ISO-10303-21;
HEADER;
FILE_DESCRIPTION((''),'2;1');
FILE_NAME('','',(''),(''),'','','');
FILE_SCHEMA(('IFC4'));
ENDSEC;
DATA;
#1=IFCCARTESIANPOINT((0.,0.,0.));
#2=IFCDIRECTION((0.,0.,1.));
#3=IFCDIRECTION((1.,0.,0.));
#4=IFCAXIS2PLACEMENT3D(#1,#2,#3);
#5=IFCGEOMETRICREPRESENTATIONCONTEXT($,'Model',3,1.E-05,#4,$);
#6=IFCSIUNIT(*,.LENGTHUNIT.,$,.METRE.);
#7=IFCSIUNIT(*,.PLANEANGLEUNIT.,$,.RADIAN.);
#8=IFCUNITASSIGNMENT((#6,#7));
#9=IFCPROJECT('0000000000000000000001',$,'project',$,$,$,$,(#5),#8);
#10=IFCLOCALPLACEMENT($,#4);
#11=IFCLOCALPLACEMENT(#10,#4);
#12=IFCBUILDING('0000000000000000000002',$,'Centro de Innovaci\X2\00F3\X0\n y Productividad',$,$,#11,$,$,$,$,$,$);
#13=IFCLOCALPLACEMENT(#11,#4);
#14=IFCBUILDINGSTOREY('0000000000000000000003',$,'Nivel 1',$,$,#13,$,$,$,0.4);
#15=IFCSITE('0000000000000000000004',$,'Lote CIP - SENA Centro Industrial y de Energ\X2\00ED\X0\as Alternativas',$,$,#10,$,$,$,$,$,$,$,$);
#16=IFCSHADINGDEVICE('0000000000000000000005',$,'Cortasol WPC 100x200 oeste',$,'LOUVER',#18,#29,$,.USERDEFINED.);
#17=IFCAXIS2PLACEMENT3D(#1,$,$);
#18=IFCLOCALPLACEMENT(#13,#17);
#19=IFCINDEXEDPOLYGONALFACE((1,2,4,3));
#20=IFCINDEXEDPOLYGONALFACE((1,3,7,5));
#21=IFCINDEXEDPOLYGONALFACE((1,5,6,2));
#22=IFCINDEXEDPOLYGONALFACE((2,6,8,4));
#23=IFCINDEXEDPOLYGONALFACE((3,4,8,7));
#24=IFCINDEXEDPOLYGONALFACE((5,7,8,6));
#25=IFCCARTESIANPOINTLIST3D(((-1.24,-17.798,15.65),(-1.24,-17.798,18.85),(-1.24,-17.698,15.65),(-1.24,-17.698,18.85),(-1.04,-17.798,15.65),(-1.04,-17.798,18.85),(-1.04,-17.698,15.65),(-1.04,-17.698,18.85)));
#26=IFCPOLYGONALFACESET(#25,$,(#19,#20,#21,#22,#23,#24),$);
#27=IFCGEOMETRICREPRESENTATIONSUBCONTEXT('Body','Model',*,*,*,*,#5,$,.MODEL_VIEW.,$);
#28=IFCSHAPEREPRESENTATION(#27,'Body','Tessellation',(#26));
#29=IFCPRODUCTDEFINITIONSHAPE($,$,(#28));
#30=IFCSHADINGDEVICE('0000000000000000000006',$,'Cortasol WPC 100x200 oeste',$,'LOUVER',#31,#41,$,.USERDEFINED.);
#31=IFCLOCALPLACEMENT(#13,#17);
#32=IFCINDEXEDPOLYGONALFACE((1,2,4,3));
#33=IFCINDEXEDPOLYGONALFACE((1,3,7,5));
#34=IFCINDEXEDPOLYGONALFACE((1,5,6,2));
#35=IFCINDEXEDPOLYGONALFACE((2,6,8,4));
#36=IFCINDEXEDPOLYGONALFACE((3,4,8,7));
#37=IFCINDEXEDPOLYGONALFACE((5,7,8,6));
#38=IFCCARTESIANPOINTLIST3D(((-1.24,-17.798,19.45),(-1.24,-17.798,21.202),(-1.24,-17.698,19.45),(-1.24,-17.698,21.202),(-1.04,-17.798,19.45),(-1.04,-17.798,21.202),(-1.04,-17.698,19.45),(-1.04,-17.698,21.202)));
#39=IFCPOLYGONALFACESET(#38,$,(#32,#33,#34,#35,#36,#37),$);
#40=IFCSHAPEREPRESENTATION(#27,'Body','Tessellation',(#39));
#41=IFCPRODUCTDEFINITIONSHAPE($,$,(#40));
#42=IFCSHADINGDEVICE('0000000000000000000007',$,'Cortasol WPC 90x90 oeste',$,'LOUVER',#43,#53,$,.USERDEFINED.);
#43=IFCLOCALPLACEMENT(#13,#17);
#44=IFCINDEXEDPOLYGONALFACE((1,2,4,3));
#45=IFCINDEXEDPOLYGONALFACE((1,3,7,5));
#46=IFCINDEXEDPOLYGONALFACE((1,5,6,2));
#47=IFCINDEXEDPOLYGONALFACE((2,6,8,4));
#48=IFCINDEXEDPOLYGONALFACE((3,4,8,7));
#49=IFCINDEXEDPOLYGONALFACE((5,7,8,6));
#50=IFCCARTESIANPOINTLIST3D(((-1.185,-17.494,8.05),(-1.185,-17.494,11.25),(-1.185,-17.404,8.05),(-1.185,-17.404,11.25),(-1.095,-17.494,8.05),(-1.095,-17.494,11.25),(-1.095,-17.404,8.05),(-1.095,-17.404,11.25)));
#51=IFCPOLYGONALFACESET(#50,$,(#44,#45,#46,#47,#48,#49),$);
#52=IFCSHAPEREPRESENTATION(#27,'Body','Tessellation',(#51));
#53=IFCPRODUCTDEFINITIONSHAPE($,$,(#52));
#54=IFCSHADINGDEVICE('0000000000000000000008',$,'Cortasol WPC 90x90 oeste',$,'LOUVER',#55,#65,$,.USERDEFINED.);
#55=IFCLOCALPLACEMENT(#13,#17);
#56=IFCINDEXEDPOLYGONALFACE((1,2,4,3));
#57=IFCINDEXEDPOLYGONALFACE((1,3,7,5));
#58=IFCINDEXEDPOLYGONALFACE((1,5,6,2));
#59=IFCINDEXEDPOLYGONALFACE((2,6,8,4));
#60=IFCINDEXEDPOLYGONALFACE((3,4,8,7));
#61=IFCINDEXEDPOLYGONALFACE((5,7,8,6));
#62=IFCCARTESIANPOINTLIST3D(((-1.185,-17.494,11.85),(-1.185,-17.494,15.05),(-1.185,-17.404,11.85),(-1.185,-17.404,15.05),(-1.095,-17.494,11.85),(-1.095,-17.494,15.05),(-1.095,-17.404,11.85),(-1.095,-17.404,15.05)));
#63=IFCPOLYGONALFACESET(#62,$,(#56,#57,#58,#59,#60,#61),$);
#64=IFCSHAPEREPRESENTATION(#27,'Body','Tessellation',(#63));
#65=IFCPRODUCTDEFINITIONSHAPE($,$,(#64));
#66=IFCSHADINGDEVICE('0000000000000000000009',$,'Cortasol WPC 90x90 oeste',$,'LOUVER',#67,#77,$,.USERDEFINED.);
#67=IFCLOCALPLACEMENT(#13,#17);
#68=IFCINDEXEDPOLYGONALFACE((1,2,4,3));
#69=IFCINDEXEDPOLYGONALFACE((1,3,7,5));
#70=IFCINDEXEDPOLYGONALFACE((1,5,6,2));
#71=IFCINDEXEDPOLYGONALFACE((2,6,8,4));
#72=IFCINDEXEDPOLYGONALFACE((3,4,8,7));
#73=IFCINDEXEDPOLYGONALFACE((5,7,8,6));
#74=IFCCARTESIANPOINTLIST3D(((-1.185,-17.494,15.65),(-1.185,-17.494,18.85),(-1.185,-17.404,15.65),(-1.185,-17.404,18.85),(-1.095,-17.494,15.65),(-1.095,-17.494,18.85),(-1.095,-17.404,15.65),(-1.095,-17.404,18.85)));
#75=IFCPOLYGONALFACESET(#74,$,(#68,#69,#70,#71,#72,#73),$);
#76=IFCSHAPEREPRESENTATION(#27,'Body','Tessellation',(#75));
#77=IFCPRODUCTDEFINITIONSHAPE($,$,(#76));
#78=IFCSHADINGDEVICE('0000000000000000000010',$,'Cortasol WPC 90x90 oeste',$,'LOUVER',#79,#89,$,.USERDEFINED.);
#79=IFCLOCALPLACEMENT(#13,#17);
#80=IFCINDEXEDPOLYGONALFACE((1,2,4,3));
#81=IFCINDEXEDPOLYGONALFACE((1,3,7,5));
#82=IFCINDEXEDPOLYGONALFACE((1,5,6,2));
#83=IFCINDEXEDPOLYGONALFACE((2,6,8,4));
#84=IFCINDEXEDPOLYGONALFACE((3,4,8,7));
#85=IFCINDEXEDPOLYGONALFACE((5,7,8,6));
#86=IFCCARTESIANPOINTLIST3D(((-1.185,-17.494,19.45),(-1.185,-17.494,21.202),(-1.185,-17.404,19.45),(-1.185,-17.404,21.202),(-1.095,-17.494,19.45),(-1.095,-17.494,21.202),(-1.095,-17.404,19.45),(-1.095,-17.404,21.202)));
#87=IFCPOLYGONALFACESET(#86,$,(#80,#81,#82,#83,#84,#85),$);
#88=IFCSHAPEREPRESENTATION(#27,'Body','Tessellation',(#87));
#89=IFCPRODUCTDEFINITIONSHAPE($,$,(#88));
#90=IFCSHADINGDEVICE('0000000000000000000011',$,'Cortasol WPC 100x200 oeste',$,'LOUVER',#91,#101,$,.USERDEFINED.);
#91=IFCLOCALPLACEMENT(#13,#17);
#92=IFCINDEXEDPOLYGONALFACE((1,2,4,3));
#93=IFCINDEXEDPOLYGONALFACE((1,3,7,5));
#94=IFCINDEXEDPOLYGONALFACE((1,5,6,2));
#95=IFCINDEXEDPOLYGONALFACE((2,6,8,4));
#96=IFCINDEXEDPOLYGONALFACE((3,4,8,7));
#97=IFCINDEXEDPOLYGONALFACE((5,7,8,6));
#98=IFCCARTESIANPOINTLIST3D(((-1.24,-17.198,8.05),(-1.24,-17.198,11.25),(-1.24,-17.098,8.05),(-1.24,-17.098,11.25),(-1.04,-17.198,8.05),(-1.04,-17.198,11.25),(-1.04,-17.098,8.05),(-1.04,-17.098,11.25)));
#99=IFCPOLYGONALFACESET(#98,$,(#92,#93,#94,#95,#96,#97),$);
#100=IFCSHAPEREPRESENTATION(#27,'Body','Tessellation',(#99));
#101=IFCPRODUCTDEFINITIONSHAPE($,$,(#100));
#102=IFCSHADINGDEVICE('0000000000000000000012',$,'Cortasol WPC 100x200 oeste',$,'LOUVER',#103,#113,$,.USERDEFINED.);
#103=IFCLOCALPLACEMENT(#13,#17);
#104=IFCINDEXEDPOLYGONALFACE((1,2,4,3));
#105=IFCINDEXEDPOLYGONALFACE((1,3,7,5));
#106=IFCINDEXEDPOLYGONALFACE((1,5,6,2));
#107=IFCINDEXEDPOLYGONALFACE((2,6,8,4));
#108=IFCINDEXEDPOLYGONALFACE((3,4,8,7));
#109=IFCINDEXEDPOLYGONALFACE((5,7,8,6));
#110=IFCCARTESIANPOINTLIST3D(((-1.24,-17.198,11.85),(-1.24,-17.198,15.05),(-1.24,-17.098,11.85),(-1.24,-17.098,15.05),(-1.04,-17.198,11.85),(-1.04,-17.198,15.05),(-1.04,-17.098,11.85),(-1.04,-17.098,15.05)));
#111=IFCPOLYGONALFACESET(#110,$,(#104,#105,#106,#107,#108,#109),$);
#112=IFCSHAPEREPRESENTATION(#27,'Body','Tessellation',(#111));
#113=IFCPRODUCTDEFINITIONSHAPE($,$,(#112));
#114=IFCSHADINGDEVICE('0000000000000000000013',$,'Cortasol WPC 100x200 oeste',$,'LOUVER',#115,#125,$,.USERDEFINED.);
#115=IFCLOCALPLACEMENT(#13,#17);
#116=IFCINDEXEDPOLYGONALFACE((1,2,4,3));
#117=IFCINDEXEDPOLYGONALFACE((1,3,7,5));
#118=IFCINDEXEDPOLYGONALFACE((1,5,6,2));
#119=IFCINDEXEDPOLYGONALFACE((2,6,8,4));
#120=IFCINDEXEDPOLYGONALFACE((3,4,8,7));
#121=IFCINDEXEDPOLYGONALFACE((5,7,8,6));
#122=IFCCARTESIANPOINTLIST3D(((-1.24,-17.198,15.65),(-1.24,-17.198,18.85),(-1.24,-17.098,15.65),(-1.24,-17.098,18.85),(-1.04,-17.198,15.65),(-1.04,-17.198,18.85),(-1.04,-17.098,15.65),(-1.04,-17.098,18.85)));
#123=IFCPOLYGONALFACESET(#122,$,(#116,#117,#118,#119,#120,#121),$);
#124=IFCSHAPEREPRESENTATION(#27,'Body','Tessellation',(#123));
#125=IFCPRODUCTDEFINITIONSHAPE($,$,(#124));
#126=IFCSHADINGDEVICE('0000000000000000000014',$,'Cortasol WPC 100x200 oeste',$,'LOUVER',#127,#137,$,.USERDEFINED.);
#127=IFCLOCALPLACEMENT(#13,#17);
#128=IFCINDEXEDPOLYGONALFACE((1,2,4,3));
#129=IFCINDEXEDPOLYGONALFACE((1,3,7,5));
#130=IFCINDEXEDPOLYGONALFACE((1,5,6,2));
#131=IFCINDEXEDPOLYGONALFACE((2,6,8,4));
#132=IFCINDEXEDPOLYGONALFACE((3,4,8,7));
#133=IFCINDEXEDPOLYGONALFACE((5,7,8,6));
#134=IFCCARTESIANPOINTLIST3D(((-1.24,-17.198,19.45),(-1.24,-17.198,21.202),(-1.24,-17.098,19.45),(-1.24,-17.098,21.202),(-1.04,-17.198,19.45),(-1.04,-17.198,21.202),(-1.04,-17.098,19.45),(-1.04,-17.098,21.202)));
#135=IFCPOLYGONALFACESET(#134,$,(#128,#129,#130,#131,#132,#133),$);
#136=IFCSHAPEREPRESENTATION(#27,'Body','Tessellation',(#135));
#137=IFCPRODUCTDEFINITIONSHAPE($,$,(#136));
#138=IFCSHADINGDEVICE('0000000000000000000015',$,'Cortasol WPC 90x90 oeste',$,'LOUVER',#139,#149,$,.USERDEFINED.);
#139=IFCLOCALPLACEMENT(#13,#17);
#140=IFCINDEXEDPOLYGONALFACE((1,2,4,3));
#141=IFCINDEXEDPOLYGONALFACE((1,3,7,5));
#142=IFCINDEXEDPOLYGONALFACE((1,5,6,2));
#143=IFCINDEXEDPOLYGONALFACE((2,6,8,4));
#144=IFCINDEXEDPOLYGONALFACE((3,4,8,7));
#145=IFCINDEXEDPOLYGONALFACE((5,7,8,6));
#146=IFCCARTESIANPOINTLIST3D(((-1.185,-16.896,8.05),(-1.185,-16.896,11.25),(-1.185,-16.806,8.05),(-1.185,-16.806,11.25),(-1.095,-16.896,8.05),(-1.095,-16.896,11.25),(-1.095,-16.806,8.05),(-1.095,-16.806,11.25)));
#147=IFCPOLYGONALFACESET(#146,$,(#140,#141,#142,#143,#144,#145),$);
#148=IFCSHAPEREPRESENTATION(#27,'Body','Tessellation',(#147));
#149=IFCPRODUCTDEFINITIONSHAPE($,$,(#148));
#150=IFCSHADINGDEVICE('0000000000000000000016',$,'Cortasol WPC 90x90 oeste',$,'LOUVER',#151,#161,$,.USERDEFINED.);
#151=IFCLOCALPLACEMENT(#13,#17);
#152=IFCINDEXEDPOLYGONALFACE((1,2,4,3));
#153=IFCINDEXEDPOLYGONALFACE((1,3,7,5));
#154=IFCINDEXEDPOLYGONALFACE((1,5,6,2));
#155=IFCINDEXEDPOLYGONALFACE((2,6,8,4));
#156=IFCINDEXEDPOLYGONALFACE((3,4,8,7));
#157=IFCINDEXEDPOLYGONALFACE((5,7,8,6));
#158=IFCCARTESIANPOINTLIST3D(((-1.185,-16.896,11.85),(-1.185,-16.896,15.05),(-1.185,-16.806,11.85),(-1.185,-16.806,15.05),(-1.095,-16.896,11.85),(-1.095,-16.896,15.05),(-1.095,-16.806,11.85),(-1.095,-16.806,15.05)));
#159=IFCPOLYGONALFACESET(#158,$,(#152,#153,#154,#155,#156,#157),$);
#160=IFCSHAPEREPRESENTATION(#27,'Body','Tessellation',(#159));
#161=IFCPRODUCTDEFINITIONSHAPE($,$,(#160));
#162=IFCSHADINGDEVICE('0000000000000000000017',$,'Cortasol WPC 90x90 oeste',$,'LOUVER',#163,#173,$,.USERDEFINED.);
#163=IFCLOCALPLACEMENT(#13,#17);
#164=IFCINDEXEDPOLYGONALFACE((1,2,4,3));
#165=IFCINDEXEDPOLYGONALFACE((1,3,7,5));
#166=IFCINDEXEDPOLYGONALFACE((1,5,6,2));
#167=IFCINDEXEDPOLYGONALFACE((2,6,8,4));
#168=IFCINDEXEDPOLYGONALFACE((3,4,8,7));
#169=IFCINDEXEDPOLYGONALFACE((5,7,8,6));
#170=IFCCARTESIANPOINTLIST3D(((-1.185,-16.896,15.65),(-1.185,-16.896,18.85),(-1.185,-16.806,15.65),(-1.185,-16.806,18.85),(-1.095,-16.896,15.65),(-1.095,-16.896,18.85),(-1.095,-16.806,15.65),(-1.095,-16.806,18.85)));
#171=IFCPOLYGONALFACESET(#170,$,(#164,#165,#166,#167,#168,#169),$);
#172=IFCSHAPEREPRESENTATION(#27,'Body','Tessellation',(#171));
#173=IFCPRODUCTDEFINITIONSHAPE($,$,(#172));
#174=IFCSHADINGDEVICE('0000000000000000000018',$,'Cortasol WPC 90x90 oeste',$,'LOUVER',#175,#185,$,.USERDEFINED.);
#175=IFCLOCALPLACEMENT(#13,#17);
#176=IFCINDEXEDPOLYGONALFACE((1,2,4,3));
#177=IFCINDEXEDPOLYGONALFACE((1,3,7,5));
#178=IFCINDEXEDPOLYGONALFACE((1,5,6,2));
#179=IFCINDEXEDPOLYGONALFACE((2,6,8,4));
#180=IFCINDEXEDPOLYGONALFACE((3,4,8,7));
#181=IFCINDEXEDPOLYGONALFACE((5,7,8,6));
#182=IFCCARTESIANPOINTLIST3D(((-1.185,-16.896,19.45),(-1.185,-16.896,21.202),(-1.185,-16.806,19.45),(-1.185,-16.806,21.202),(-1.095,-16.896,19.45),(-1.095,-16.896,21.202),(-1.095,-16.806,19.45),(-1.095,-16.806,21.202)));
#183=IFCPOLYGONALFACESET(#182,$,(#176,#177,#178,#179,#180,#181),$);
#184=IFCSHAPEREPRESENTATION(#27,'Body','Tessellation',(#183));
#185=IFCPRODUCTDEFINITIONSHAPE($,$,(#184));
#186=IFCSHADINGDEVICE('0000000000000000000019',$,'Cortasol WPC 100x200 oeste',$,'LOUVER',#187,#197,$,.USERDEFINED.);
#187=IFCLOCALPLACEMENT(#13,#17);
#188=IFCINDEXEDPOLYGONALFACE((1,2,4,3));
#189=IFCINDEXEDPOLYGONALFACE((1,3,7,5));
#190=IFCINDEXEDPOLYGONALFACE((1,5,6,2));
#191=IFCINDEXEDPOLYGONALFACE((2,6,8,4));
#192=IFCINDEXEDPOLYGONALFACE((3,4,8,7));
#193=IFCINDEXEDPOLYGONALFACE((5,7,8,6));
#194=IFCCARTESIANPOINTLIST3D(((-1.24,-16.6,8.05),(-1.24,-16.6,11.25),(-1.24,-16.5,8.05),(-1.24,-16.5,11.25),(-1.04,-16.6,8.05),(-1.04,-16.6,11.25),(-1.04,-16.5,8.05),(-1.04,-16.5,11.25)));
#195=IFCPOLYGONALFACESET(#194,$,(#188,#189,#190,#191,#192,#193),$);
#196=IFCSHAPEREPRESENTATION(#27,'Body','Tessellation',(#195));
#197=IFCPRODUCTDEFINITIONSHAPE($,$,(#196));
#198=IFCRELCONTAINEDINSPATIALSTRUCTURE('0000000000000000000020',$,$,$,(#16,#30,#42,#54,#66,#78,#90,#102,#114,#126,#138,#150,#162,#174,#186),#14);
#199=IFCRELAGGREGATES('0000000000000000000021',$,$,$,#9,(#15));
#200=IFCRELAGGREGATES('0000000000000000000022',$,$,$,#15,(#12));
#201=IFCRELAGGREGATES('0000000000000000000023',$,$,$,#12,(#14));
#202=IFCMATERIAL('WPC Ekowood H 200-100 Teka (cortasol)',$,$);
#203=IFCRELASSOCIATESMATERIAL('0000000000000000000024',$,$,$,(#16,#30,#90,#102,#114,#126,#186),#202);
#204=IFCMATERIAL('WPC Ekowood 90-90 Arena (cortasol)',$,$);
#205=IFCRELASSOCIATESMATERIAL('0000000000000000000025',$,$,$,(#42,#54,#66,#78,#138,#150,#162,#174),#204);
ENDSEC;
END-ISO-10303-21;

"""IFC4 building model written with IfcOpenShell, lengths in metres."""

from ifc_helpers import new_model, si_unit, frame, origin_with_axes, place, context, subcontext, project, spatial, polyline, outline, extrude, material, element, save


model = new_model("IFC4")

# Units and contexts
model_context = context("Model", 3, precision=1e-05, world=origin_with_axes())
body_context = subcontext(model_context, "Body", "Model", "MODEL_VIEW")
ifc_project = project(units=[si_unit("LENGTHUNIT", "METRE"), si_unit("PLANEANGLEUNIT", "RADIAN")], contexts=[model_context])

# Site, building, storey
site_placement = place(None, origin_with_axes())
site = spatial("IfcSite", under=ifc_project, at=site_placement, Name="Lote CIP - SENA Centro Industrial y de Energías Alternativas")
building_placement = place(site_placement, origin_with_axes())
building = spatial("IfcBuilding", under=site, at=building_placement, Name="Centro de Innovación y Productividad")
storey_placement = place(building_placement, origin_with_axes())
storey = spatial("IfcBuildingStorey", under=building, at=storey_placement, Name="Nivel 1", Elevation=0.4)

# Shading devices
ifc_material_1 = material(Name="WPC Ekowood H 200-100 Teka (cortasol)")
shading_device_1_placement = place(storey_placement, origin_with_axes())
element("IfcShadingDevice", 1, at=shading_device_1_placement, inside=storey, material=ifc_material_1, Name="Cortasol WPC 100x200 oeste", ObjectType="LOUVER", PredefinedType="USERDEFINED", context=body_context, shape_type="SweptSolid", body=[
    extrude(outline(polyline([(-1.04, -17.798), (-1.24, -17.798), (-1.24, -17.698), (-1.04, -17.698), (-1.04, -17.798)])), frame((0.0, 0.0, 15.65)), (0.0, 0.0, 1.0), 3.2),
])
shading_device_2_placement = place(storey_placement, origin_with_axes())
element("IfcShadingDevice", 2, at=shading_device_2_placement, inside=storey, material=ifc_material_1, Name="Cortasol WPC 100x200 oeste", ObjectType="LOUVER", PredefinedType="USERDEFINED", context=body_context, shape_type="SweptSolid", body=[
    extrude(outline(polyline([(-1.04, -17.798), (-1.24, -17.798), (-1.24, -17.698), (-1.04, -17.698), (-1.04, -17.798)])), frame((0.0, 0.0, 19.45)), (0.0, 0.0, 1.0), 1.752),
])
ifc_material_2 = material(Name="WPC Ekowood 90-90 Arena (cortasol)")
shading_device_3_placement = place(storey_placement, origin_with_axes())
element("IfcShadingDevice", 3, at=shading_device_3_placement, inside=storey, material=ifc_material_2, Name="Cortasol WPC 90x90 oeste", ObjectType="LOUVER", PredefinedType="USERDEFINED", context=body_context, shape_type="SweptSolid", body=[
    extrude(outline(polyline([(-1.095, -17.494), (-1.185, -17.494), (-1.185, -17.404), (-1.095, -17.404), (-1.095, -17.494)])), frame((0.0, 0.0, 8.05)), (0.0, 0.0, 1.0), 3.2),
])
shading_device_4_placement = place(storey_placement, origin_with_axes())
element("IfcShadingDevice", 4, at=shading_device_4_placement, inside=storey, material=ifc_material_2, Name="Cortasol WPC 90x90 oeste", ObjectType="LOUVER", PredefinedType="USERDEFINED", context=body_context, shape_type="SweptSolid", body=[
    extrude(outline(polyline([(-1.095, -17.494), (-1.185, -17.494), (-1.185, -17.404), (-1.095, -17.404), (-1.095, -17.494)])), frame((0.0, 0.0, 11.85)), (0.0, 0.0, 1.0), 3.2),
])
shading_device_5_placement = place(storey_placement, origin_with_axes())
element("IfcShadingDevice", 5, at=shading_device_5_placement, inside=storey, material=ifc_material_2, Name="Cortasol WPC 90x90 oeste", ObjectType="LOUVER", PredefinedType="USERDEFINED", context=body_context, shape_type="SweptSolid", body=[
    extrude(outline(polyline([(-1.095, -17.494), (-1.185, -17.494), (-1.185, -17.404), (-1.095, -17.404), (-1.095, -17.494)])), frame((0.0, 0.0, 15.65)), (0.0, 0.0, 1.0), 3.2),
])
shading_device_6_placement = place(storey_placement, origin_with_axes())
element("IfcShadingDevice", 6, at=shading_device_6_placement, inside=storey, material=ifc_material_2, Name="Cortasol WPC 90x90 oeste", ObjectType="LOUVER", PredefinedType="USERDEFINED", context=body_context, shape_type="SweptSolid", body=[
    extrude(outline(polyline([(-1.095, -17.494), (-1.185, -17.494), (-1.185, -17.404), (-1.095, -17.404), (-1.095, -17.494)])), frame((0.0, 0.0, 19.45)), (0.0, 0.0, 1.0), 1.752),
])
shading_device_7_placement = place(storey_placement, origin_with_axes())
element("IfcShadingDevice", 7, at=shading_device_7_placement, inside=storey, material=ifc_material_1, Name="Cortasol WPC 100x200 oeste", ObjectType="LOUVER", PredefinedType="USERDEFINED", context=body_context, shape_type="SweptSolid", body=[
    extrude(outline(polyline([(-1.04, -17.198), (-1.24, -17.198), (-1.24, -17.098), (-1.04, -17.098), (-1.04, -17.198)])), frame((0.0, 0.0, 8.05)), (0.0, 0.0, 1.0), 3.2),
])
shading_device_8_placement = place(storey_placement, origin_with_axes())
element("IfcShadingDevice", 8, at=shading_device_8_placement, inside=storey, material=ifc_material_1, Name="Cortasol WPC 100x200 oeste", ObjectType="LOUVER", PredefinedType="USERDEFINED", context=body_context, shape_type="SweptSolid", body=[
    extrude(outline(polyline([(-1.04, -17.198), (-1.24, -17.198), (-1.24, -17.098), (-1.04, -17.098), (-1.04, -17.198)])), frame((0.0, 0.0, 11.85)), (0.0, 0.0, 1.0), 3.2),
])
shading_device_9_placement = place(storey_placement, origin_with_axes())
element("IfcShadingDevice", 9, at=shading_device_9_placement, inside=storey, material=ifc_material_1, Name="Cortasol WPC 100x200 oeste", ObjectType="LOUVER", PredefinedType="USERDEFINED", context=body_context, shape_type="SweptSolid", body=[
    extrude(outline(polyline([(-1.04, -17.198), (-1.24, -17.198), (-1.24, -17.098), (-1.04, -17.098), (-1.04, -17.198)])), frame((0.0, 0.0, 15.65)), (0.0, 0.0, 1.0), 3.2),
])
shading_device_10_placement = place(storey_placement, origin_with_axes())
element("IfcShadingDevice", 10, at=shading_device_10_placement, inside=storey, material=ifc_material_1, Name="Cortasol WPC 100x200 oeste", ObjectType="LOUVER", PredefinedType="USERDEFINED", context=body_context, shape_type="SweptSolid", body=[
    extrude(outline(polyline([(-1.04, -17.198), (-1.24, -17.198), (-1.24, -17.098), (-1.04, -17.098), (-1.04, -17.198)])), frame((0.0, 0.0, 19.45)), (0.0, 0.0, 1.0), 1.752),
])
shading_device_11_placement = place(storey_placement, origin_with_axes())
element("IfcShadingDevice", 11, at=shading_device_11_placement, inside=storey, material=ifc_material_2, Name="Cortasol WPC 90x90 oeste", ObjectType="LOUVER", PredefinedType="USERDEFINED", context=body_context, shape_type="SweptSolid", body=[
    extrude(outline(polyline([(-1.095, -16.896), (-1.185, -16.896), (-1.185, -16.806), (-1.095, -16.806), (-1.095, -16.896)])), frame((0.0, 0.0, 8.05)), (0.0, 0.0, 1.0), 3.2),
])
shading_device_12_placement = place(storey_placement, origin_with_axes())
element("IfcShadingDevice", 12, at=shading_device_12_placement, inside=storey, material=ifc_material_2, Name="Cortasol WPC 90x90 oeste", ObjectType="LOUVER", PredefinedType="USERDEFINED", context=body_context, shape_type="SweptSolid", body=[
    extrude(outline(polyline([(-1.095, -16.896), (-1.185, -16.896), (-1.185, -16.806), (-1.095, -16.806), (-1.095, -16.896)])), frame((0.0, 0.0, 11.85)), (0.0, 0.0, 1.0), 3.2),
])
shading_device_13_placement = place(storey_placement, origin_with_axes())
element("IfcShadingDevice", 13, at=shading_device_13_placement, inside=storey, material=ifc_material_2, Name="Cortasol WPC 90x90 oeste", ObjectType="LOUVER", PredefinedType="USERDEFINED", context=body_context, shape_type="SweptSolid", body=[
    extrude(outline(polyline([(-1.095, -16.896), (-1.185, -16.896), (-1.185, -16.806), (-1.095, -16.806), (-1.095, -16.896)])), frame((0.0, 0.0, 15.65)), (0.0, 0.0, 1.0), 3.2),
])
shading_device_14_placement = place(storey_placement, origin_with_axes())
element("IfcShadingDevice", 14, at=shading_device_14_placement, inside=storey, material=ifc_material_2, Name="Cortasol WPC 90x90 oeste", ObjectType="LOUVER", PredefinedType="USERDEFINED", context=body_context, shape_type="SweptSolid", body=[
    extrude(outline(polyline([(-1.095, -16.896), (-1.185, -16.896), (-1.185, -16.806), (-1.095, -16.806), (-1.095, -16.896)])), frame((0.0, 0.0, 19.45)), (0.0, 0.0, 1.0), 1.752),
])
shading_device_15_placement = place(storey_placement, origin_with_axes())
element("IfcShadingDevice", 15, at=shading_device_15_placement, inside=storey, material=ifc_material_1, Name="Cortasol WPC 100x200 oeste", ObjectType="LOUVER", PredefinedType="USERDEFINED", context=body_context, shape_type="SweptSolid", body=[
    extrude(outline(polyline([(-1.04, -16.6), (-1.24, -16.6), (-1.24, -16.5), (-1.04, -16.5), (-1.04, -16.6)])), frame((0.0, 0.0, 8.05)), (0.0, 0.0, 1.0), 3.2),
])

save(model, "model.ifc")
